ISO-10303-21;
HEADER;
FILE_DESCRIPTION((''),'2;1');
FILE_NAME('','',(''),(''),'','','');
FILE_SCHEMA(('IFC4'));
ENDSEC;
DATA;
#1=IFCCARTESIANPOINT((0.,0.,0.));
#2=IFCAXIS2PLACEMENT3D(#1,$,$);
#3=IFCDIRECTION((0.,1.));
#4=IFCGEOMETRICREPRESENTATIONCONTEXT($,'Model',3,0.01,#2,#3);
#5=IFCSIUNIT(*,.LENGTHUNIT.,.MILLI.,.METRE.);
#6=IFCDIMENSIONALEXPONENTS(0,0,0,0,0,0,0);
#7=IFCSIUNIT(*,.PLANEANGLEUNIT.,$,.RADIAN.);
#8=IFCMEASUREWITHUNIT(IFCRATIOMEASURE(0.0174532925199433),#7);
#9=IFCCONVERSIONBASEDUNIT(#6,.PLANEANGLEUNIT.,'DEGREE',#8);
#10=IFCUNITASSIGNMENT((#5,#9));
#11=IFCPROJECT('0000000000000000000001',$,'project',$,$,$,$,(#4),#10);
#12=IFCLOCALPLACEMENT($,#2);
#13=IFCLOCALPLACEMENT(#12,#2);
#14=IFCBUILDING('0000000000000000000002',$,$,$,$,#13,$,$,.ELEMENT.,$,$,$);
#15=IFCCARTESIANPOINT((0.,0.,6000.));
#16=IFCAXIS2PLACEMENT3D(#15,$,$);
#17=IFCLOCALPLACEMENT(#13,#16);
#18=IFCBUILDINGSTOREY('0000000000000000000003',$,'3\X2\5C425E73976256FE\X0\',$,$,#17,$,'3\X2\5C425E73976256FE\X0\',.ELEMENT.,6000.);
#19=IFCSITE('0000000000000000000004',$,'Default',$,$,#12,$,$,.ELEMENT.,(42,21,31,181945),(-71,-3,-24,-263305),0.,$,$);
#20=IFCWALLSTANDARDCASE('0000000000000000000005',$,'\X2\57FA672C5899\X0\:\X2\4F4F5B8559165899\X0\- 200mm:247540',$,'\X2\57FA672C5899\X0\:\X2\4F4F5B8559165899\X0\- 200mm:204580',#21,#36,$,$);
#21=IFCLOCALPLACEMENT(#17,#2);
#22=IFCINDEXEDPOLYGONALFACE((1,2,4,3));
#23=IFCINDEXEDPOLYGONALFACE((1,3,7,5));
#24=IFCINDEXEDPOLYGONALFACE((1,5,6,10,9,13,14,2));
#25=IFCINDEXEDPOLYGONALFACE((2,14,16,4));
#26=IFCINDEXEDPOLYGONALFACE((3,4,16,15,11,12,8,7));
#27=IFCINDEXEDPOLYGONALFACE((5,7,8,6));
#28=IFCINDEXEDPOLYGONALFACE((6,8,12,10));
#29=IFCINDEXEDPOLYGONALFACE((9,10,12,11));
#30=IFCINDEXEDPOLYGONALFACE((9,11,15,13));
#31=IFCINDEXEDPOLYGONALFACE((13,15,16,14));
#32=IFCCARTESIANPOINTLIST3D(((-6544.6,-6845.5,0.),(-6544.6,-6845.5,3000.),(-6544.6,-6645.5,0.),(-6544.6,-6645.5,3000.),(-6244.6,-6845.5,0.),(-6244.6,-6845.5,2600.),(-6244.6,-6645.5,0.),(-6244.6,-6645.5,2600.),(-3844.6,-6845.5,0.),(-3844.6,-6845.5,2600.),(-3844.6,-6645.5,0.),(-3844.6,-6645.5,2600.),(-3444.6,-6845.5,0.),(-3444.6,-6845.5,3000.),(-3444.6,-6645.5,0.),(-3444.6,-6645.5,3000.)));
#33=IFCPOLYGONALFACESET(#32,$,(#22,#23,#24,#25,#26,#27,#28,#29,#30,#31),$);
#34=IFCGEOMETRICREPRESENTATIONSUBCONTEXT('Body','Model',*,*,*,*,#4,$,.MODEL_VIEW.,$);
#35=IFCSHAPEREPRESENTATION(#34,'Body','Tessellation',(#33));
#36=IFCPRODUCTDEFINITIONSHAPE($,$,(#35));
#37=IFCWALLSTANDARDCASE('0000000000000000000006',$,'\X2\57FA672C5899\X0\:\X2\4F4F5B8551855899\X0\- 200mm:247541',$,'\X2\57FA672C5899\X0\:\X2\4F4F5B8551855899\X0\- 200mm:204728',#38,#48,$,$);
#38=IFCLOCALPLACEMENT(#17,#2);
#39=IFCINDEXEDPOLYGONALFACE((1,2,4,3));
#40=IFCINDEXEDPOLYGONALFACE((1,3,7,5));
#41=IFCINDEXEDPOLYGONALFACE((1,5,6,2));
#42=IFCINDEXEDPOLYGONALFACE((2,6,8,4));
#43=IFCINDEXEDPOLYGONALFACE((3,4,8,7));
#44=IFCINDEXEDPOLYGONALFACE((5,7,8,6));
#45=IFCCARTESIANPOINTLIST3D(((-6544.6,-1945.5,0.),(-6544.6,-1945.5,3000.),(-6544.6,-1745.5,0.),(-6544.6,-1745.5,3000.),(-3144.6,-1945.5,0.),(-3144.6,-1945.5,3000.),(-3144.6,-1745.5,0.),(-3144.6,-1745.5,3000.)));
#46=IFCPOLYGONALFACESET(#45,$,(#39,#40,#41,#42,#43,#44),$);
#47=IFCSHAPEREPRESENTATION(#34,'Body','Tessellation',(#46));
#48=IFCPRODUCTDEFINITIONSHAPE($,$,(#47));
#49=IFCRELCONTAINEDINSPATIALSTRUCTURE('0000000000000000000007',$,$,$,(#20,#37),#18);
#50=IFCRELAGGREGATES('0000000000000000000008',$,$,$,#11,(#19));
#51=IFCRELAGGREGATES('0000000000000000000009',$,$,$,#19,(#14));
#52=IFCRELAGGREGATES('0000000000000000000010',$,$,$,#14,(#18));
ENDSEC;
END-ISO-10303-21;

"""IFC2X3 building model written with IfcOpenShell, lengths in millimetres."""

from ifc_helpers import new_model, entity, si_unit, converted_unit, direction, frame, frame_2d, origin, place, context, subcontext, project, spatial, polyline, rectangle, extrude, clip, bounded_halfspace, element, save


model = new_model("IFC2X3")

# Units and contexts
model_context = context("Model", 3, precision=0.01, world=origin(), true_north=direction((0.0, 1.0)))
body_context = subcontext(model_context, "Body", "Model", "MODEL_VIEW")
ifc_project = project(units=[si_unit("LENGTHUNIT", "METRE", prefix="MILLI"), converted_unit("PLANEANGLEUNIT", "DEGREE", entity("IfcRatioMeasure", 0.0174532925199433), si_unit("PLANEANGLEUNIT", "RADIAN"), dimensions=[0, 0, 0, 0, 0, 0, 0])], contexts=[model_context])

# Site, building, storey
site_placement = place(None, origin())
site = spatial("IfcSite", under=ifc_project, at=site_placement, Name="Default", CompositionType="ELEMENT", RefLatitude=(42, 21, 31, 181945), RefLongitude=(-71, -3, -24, -263305), RefElevation=0.0)
building_placement = place(site_placement, origin())
building = spatial("IfcBuilding", under=site, at=building_placement, CompositionType="ELEMENT")
storey_placement = place(building_placement, frame((0.0, 0.0, 6000.0)))
storey = spatial("IfcBuildingStorey", under=building, at=storey_placement, Name="3层平面图", LongName="3层平面图", CompositionType="ELEMENT", Elevation=6000.0)

# Wall, opening
wall_1_placement = place(storey_placement, frame((-3444.6, -6745.5, 0.0), z_axis=(0.0, 0.0, 1.0), x_axis=(-1.0, 0.0, 0.0)))
wall_1 = element("IfcWallStandardCase", 1, at=wall_1_placement, inside=storey, Name="基本墙:住宅外墙- 200mm:247540", ObjectType="基本墙:住宅外墙- 200mm:204580", context=body_context, shape_type="Clipping", body=[
    clip(clip(extrude(rectangle(XDim=3100.0, YDim=200.0, at=frame_2d((1550.0, 0.0), x_axis=(-1.0, 0.0))), origin(), (0.0, 0.0, 1.0), 3000.0), bounded_halfspace(frame((0.0, -100.0, 0.0), z_axis=(1.0, 0.0, 0.0), x_axis=(0.0, 0.0, -1.0)), True, frame((0.0, -100.0, 0.0), z_axis=(1.0, 0.0, 0.0), x_axis=(0.0, 0.0, -1.0)), polyline([(0.0, 0.0), (0.0, 200.0), (-3000.0, 200.0), (-3000.0, 0.0), (0.0, 0.0)]))), bounded_halfspace(frame((3100.0, -100.0, 3000.0), z_axis=(-1.0, 0.0, 0.0), x_axis=(0.0, 0.0, -1.0)), True, frame((3100.0, -100.0, 3000.0), z_axis=(-1.0, 0.0, 0.0), x_axis=(0.0, 0.0, -1.0)), polyline([(0.0, 0.0), (0.0, -200.0), (3000.0, -200.0), (3000.0, 0.0), (0.0, 0.0)]))),
])
opening_1_placement = place(wall_1_placement, frame((400.0, -100.0, 0.0)))
element("IfcOpeningElement", 2, at=opening_1_placement, cuts=wall_1, ObjectType="Opening", context=body_context, shape_type="SweptSolid", body=[
    extrude(rectangle(XDim=2600.0, YDim=2400.0, at=frame_2d((1300.0, 1200.0), x_axis=(1.0, 0.0))), frame((0.0, 0.0, 0.0), z_axis=(0.0, 1.0, 0.0), x_axis=(0.0, 0.0, 1.0)), (0.0, 0.0, 1.0), 200.0),
])

# Wall
wall_2_placement = place(storey_placement, frame((-6544.6, -1845.5, 0.0)))
element("IfcWallStandardCase", 3, at=wall_2_placement, inside=storey, Name="基本墙:住宅内墙- 200mm:247541", ObjectType="基本墙:住宅内墙- 200mm:204728", context=body_context, shape_type="Clipping", body=[
    clip(extrude(rectangle(XDim=3400.0, YDim=200.0, at=frame_2d((1700.0, 0.0), x_axis=(-1.0, 0.0))), origin(), (0.0, 0.0, 1.0), 3000.0), bounded_halfspace(frame((0.0, -100.0, 0.0), z_axis=(1.0, 0.0, 0.0), x_axis=(0.0, 0.0, -1.0)), True, frame((0.0, -100.0, 0.0), z_axis=(1.0, 0.0, 0.0), x_axis=(0.0, 0.0, -1.0)), polyline([(0.0, 0.0), (0.0, 200.0), (-3000.0, 200.0), (-3000.0, 0.0), (0.0, 0.0)]))),
])

save(model, "model.ifc")
